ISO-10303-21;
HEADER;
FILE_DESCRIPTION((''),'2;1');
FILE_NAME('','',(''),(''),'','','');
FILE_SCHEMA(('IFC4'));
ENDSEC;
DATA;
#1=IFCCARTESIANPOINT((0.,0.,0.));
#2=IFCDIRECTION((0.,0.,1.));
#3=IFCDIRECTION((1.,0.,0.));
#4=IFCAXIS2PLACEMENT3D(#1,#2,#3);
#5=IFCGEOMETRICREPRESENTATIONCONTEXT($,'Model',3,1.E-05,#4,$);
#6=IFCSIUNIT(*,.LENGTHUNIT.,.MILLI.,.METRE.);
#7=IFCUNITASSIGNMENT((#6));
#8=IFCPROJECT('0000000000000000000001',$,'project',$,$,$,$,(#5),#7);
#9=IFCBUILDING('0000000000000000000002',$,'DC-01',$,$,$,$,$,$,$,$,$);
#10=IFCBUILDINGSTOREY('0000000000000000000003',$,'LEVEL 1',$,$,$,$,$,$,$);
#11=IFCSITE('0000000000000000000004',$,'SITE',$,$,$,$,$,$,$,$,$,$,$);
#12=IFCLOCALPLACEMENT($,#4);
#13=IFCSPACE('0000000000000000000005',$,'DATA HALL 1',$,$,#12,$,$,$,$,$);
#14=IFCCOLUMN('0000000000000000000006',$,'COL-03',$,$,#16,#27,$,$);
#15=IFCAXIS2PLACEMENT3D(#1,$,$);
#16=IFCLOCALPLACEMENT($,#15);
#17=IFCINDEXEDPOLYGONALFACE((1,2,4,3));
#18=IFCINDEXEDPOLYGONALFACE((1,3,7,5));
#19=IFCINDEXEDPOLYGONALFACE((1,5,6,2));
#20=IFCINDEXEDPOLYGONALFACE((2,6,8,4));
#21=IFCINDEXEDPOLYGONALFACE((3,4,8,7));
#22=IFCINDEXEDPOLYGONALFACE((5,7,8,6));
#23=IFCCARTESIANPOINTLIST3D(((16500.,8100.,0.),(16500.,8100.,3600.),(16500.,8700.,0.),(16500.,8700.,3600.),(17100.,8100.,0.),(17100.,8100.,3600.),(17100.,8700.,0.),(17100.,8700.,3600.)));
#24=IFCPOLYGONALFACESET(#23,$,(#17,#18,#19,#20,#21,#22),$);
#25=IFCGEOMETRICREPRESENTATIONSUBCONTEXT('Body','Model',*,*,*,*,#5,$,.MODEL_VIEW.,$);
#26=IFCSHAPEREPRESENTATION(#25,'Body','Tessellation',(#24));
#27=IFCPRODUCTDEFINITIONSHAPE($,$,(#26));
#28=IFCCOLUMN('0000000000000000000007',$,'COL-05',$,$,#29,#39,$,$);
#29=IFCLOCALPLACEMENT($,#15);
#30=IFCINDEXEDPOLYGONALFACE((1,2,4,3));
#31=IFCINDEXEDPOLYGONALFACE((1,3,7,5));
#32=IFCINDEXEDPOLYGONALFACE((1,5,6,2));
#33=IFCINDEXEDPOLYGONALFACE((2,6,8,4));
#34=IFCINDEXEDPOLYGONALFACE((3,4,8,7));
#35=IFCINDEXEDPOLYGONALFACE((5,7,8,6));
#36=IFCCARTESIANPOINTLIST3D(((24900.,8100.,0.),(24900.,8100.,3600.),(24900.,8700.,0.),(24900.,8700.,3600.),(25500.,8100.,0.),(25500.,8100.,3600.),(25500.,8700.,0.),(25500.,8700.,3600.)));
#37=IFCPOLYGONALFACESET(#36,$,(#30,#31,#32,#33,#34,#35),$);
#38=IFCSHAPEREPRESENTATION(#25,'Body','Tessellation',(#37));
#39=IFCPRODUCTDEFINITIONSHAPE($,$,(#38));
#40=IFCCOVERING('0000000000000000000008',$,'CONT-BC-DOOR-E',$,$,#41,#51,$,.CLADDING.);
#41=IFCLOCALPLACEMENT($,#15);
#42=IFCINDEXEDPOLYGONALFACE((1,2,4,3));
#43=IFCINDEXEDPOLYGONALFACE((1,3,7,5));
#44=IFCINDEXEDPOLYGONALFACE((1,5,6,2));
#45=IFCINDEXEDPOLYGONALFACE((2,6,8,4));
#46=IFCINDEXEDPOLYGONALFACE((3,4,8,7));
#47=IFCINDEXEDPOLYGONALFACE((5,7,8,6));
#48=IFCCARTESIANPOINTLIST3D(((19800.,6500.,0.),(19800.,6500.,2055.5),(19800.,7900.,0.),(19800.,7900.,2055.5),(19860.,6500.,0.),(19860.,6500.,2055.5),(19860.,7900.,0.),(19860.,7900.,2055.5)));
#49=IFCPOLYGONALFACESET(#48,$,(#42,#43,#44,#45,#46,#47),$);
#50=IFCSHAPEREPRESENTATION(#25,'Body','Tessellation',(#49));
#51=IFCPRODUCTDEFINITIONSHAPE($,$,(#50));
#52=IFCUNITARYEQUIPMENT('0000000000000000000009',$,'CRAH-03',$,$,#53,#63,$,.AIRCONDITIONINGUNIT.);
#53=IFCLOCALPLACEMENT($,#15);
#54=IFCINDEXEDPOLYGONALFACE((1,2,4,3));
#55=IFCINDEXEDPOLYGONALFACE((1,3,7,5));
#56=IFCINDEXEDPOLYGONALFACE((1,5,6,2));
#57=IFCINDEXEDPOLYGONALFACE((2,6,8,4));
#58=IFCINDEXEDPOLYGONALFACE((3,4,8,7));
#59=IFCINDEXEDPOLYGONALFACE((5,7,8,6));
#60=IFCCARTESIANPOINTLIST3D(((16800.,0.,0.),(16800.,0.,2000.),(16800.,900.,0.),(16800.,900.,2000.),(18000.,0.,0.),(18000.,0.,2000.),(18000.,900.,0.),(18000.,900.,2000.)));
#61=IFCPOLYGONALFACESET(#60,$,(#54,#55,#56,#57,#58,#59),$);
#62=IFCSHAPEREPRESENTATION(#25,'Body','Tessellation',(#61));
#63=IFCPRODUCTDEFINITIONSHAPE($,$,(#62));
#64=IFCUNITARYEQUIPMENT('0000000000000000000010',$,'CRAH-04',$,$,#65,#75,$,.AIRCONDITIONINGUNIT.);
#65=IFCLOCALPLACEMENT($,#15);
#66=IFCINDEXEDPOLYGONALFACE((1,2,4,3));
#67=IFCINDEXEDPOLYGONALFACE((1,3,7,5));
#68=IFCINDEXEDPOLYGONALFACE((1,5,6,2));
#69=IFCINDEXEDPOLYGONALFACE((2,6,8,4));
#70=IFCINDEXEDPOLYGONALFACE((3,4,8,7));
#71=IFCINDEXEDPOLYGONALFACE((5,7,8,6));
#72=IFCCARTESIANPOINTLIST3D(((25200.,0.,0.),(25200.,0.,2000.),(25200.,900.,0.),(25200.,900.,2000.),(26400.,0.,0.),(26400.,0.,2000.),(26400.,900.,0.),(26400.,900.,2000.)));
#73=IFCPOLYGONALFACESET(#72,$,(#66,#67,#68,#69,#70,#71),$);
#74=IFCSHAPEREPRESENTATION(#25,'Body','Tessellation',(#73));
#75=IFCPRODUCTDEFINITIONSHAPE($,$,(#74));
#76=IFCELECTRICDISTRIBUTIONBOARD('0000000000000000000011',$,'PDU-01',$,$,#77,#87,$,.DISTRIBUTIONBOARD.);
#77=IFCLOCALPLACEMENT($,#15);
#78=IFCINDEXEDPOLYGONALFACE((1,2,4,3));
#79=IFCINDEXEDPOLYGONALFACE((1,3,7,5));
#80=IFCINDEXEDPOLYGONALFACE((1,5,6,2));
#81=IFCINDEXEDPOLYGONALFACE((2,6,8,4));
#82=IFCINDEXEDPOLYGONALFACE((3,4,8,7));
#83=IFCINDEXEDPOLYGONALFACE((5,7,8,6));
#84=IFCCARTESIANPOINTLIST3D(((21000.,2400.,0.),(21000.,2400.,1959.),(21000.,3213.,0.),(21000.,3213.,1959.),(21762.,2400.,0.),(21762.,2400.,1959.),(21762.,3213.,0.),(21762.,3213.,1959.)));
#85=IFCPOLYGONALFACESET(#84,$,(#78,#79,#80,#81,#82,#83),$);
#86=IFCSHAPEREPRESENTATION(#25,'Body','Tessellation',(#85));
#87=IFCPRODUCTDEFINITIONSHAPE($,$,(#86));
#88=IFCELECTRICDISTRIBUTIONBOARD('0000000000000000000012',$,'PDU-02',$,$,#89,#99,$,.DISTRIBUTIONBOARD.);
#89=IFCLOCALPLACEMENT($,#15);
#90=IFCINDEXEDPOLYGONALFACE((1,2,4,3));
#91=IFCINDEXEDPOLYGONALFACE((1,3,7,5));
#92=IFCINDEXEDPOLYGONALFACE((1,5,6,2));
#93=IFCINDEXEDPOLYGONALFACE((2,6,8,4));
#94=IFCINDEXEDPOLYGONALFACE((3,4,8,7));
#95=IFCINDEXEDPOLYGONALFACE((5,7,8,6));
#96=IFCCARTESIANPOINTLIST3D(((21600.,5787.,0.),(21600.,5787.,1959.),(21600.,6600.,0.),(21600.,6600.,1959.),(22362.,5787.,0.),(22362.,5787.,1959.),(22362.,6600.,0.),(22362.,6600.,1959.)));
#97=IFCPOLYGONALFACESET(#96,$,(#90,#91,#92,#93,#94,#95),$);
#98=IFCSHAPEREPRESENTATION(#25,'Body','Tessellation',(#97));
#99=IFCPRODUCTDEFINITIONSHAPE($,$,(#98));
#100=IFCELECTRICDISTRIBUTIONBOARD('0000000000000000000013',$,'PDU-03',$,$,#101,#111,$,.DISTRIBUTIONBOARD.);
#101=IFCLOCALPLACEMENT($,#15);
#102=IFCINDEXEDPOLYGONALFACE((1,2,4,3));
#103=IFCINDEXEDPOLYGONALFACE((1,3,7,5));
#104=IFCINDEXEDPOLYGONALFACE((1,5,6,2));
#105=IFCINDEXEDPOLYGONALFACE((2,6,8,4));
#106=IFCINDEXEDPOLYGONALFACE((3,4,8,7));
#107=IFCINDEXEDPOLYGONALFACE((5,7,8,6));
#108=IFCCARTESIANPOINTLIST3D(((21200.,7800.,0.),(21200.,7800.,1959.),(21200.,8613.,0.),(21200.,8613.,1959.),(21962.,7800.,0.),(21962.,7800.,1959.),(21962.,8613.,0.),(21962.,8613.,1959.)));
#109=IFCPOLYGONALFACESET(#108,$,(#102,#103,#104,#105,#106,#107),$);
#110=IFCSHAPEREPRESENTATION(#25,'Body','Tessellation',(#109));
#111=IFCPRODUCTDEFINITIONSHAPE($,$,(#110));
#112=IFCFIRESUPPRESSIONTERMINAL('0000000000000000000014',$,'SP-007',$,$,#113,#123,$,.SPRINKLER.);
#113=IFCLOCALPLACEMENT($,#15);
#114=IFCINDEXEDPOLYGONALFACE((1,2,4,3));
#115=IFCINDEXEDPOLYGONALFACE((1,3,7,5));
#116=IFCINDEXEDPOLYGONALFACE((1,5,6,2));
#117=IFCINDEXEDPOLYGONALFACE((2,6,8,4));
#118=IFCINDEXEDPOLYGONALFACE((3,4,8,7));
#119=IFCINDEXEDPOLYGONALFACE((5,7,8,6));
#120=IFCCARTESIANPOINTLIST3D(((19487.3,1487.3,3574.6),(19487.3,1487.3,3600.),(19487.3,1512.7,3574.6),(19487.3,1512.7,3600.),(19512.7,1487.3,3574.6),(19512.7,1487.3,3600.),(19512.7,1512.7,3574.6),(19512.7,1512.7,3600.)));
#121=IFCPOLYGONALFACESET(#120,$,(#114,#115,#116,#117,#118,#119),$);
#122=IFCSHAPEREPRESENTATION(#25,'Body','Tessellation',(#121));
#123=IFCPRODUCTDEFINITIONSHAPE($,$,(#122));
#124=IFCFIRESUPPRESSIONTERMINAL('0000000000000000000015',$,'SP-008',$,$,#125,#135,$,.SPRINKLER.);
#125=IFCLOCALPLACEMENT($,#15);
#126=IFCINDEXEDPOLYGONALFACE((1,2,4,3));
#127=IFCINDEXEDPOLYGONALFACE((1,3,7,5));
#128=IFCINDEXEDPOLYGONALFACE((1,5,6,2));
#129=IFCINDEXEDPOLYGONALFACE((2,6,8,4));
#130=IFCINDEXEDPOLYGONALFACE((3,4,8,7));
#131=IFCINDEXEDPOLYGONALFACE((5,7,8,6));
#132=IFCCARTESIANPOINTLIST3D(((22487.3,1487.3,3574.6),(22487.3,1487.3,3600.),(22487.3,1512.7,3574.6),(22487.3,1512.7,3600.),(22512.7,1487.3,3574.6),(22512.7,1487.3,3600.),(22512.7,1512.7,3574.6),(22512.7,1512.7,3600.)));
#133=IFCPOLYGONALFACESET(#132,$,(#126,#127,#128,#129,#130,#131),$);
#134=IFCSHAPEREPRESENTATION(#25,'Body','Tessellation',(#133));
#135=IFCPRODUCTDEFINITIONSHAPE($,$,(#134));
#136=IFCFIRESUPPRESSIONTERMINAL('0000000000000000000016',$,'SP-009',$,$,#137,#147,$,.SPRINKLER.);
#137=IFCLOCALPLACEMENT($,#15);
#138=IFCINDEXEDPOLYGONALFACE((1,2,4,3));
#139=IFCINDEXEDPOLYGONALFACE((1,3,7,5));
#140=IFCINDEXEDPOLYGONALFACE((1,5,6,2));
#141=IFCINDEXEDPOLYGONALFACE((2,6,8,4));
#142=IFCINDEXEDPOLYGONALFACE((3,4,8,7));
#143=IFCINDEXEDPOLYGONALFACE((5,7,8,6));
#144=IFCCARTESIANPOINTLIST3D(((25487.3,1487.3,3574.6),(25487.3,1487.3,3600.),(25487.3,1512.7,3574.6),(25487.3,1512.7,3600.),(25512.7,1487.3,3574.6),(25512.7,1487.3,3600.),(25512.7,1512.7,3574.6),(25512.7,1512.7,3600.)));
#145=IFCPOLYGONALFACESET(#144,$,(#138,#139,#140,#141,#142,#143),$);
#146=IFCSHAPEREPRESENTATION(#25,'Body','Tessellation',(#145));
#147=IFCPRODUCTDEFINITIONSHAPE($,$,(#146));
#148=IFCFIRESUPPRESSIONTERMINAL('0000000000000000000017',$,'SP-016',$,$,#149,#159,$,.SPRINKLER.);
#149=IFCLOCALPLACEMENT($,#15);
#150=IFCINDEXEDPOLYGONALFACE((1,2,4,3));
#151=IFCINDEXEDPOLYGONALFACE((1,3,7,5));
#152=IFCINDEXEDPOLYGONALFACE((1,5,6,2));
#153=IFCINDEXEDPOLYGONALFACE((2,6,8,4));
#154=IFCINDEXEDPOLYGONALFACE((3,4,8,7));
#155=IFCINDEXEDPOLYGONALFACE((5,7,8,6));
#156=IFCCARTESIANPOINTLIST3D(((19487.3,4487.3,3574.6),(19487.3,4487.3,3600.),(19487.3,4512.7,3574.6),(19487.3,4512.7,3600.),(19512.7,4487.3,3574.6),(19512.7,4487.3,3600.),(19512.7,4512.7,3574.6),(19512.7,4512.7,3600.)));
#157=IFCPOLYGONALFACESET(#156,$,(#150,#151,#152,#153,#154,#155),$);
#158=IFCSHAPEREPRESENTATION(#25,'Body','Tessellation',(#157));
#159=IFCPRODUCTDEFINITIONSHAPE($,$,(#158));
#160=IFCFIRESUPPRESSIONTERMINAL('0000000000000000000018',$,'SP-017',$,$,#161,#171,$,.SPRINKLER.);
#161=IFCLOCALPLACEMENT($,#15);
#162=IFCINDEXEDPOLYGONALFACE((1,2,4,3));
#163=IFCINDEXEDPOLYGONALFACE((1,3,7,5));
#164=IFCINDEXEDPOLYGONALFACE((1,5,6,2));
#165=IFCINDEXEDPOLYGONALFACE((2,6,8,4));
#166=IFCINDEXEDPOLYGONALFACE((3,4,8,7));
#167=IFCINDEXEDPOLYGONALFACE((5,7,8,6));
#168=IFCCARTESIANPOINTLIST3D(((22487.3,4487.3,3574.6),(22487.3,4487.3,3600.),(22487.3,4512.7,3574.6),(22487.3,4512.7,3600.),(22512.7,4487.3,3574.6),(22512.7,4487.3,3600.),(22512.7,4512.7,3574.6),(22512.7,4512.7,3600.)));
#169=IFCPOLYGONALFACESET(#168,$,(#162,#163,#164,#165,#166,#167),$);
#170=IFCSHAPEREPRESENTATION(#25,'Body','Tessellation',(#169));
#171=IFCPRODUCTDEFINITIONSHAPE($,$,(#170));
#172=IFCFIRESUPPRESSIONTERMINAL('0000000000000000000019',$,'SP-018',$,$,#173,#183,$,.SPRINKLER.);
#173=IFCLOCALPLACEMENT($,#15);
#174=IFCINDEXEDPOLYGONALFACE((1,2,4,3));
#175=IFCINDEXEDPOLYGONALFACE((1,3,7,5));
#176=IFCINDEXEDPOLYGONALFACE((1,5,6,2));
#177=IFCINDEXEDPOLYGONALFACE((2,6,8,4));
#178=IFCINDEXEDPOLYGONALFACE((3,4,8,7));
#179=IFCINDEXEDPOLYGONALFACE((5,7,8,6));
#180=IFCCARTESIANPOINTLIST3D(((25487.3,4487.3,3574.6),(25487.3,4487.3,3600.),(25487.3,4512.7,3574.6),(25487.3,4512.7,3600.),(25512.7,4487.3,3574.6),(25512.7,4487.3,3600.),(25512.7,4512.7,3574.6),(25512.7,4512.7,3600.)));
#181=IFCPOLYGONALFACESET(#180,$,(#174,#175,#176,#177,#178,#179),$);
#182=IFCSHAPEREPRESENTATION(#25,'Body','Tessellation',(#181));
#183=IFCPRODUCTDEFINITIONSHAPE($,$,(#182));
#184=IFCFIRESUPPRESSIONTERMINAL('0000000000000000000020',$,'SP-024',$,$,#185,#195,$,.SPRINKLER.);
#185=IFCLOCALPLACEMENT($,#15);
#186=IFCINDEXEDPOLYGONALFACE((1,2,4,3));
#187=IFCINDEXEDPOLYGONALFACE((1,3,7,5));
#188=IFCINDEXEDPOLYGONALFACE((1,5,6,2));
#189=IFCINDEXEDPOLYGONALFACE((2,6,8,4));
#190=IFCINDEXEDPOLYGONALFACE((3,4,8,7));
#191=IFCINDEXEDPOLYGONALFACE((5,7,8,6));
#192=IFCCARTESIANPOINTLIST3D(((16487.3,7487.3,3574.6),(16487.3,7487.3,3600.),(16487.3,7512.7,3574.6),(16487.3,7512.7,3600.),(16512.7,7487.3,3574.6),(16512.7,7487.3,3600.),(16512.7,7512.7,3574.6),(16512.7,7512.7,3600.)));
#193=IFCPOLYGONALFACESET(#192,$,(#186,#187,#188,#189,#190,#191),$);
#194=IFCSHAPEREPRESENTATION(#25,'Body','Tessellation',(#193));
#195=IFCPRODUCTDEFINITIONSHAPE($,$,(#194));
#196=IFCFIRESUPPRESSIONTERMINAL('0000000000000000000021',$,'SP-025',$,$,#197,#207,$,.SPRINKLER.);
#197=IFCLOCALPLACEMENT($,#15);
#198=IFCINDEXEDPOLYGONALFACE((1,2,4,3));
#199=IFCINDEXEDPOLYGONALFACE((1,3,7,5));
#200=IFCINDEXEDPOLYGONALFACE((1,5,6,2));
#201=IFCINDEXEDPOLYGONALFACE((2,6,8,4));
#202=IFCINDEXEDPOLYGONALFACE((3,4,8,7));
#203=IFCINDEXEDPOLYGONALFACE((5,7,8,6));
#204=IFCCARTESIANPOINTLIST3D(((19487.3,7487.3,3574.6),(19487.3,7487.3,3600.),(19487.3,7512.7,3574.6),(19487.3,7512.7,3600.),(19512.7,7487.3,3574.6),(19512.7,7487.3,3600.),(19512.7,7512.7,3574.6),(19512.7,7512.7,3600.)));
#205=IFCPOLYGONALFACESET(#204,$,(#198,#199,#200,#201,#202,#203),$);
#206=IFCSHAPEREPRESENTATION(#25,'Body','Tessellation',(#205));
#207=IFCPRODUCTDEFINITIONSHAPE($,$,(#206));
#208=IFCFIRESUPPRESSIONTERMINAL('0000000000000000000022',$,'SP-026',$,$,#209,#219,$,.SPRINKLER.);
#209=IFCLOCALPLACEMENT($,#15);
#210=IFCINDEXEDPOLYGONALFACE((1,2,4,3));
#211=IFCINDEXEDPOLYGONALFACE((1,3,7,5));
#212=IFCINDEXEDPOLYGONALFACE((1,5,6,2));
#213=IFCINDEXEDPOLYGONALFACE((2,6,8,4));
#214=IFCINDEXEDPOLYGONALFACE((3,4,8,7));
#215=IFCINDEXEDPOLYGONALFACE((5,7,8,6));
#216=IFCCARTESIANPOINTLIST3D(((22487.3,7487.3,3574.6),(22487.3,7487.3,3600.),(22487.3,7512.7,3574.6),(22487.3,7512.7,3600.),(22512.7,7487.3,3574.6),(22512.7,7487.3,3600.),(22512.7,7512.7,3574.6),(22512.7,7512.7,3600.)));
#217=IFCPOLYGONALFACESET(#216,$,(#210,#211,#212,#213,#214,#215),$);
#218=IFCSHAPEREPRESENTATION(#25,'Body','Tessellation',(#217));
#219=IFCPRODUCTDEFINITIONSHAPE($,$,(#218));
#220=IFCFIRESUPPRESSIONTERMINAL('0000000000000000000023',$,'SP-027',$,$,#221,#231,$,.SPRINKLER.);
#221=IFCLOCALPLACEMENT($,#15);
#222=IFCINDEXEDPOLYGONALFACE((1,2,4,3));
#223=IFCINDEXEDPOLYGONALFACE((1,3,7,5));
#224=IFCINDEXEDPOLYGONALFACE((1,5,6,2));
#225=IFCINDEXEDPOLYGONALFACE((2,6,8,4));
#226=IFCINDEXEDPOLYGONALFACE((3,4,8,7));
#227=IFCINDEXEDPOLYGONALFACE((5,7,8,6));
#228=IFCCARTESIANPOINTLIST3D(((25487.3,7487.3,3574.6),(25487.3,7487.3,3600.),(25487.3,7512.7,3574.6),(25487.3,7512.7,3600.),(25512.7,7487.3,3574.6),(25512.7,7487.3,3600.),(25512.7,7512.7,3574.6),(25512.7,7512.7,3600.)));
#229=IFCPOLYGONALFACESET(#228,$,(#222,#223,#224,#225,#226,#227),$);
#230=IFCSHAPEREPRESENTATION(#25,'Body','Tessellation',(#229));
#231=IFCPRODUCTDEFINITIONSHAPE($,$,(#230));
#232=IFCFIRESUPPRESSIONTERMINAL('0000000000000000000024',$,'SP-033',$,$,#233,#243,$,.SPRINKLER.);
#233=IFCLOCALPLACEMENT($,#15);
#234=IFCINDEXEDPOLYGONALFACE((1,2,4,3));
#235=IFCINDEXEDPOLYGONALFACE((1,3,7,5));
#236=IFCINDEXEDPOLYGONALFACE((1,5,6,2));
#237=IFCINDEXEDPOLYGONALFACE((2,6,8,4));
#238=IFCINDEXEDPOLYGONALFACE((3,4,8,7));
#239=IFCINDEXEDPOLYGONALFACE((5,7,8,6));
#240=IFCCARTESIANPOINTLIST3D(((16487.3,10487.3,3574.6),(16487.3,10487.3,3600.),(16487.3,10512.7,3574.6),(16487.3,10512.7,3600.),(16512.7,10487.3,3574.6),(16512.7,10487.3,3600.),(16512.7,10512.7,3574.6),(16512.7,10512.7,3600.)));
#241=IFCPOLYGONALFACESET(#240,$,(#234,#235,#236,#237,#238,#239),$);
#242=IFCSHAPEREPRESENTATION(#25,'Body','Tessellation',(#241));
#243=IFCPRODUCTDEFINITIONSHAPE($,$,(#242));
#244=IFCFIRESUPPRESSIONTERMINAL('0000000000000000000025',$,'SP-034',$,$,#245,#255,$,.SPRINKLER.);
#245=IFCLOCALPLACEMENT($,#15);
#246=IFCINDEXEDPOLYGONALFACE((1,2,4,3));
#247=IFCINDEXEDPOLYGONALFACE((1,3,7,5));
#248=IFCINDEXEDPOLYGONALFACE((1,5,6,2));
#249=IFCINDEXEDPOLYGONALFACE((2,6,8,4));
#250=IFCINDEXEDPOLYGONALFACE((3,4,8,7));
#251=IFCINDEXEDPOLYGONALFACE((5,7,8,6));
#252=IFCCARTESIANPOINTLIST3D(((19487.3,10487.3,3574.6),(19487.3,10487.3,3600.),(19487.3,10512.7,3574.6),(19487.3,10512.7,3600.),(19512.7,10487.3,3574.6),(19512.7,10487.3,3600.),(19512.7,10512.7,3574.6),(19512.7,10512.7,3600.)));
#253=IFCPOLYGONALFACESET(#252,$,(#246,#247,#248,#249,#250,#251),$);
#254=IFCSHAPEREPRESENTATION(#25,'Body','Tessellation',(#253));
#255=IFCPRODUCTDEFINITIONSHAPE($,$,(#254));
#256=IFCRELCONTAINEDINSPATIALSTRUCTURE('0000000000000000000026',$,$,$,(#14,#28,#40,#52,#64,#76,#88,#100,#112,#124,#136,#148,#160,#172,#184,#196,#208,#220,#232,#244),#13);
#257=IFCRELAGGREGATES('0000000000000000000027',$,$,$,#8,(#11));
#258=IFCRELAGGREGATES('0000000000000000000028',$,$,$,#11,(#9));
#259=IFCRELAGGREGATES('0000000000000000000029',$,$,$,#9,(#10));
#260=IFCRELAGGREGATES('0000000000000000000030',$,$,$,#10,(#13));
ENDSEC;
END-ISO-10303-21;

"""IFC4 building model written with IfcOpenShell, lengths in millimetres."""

from ifc_helpers import new_model, si_unit, frame, origin, origin_with_axes, place, context, subcontext, project, spatial, polyline, outline, extrude, element, save


model = new_model("IFC4")

# Units and contexts
model_context = context("Model", 3, precision=1e-05, world=origin_with_axes())
body_context = subcontext(model_context, "Body", "Model", "MODEL_VIEW")
ifc_project = project(units=[si_unit("LENGTHUNIT", "METRE", prefix="MILLI")], contexts=[model_context])

# Site, building, storey, space
site = spatial("IfcSite", under=ifc_project, Name="SITE")
building = spatial("IfcBuilding", under=site, Name="DC-01")
storey = spatial("IfcBuildingStorey", under=building, Name="LEVEL 1")
space_placement = place(None, origin_with_axes())
space = spatial("IfcSpace", under=storey, at=space_placement, Name="DATA HALL 1")

# Columns
for number, where, z_axis, x_axis, name in (
    (1, (16500.0, 8100.0, 0.0), (0.0, 0.0, 1.0), (1.0, 0.0, 0.0), "COL-03"),
    (2, (24900.0, 8100.0, 0.0), (0.0, 0.0, 1.0), (1.0, 0.0, 0.0), "COL-05"),
):
    element("IfcColumn", number, at=place(space_placement, frame(where, z_axis=z_axis, x_axis=x_axis)), inside=space, Name=name, context=body_context, shape_type="SweptSolid", body=[
        extrude(outline(polyline([(0.0, 0.0), (600.0, 0.0), (600.0, 600.0), (0.0, 600.0), (0.0, 0.0)])), origin(), (0.0, 0.0, 1.0), 3600.0),
    ])

# Covering
covering_placement = place(space_placement, frame((19800.0, 6500.0, 0.0), z_axis=(0.0, 0.0, 1.0), x_axis=(1.0, 0.0, 0.0)))
element("IfcCovering", 3, at=covering_placement, inside=space, Name="CONT-BC-DOOR-E", PredefinedType="CLADDING", context=body_context, shape_type="SweptSolid", body=[
    extrude(outline(polyline([(0.0, 0.0), (60.0, 0.0), (60.0, 1400.0), (0.0, 1400.0), (0.0, 0.0)])), origin(), (0.0, 0.0, 1.0), 2055.5),
])

# Unitary equipment
for number, where, z_axis, x_axis, name in (
    (4, (16800.0, 0.0, 0.0), (0.0, 0.0, 1.0), (1.0, 0.0, 0.0), "CRAH-03"),
    (5, (25200.0, 0.0, 0.0), (0.0, 0.0, 1.0), (1.0, 0.0, 0.0), "CRAH-04"),
):
    element("IfcUnitaryEquipment", number, at=place(space_placement, frame(where, z_axis=z_axis, x_axis=x_axis)), inside=space, Name=name, PredefinedType="AIRCONDITIONINGUNIT", context=body_context, shape_type="SweptSolid", body=[
        extrude(outline(polyline([(0.0, 0.0), (1200.0, 0.0), (1200.0, 900.0), (0.0, 900.0), (0.0, 0.0)])), origin(), (0.0, 0.0, 1.0), 2000.0),
    ])

# Electric distribution boards
for number, where, z_axis, x_axis, name in (
    (6, (21762.0, 3213.0, 0.0), (0.0, 0.0, 1.0), (-1.0, 0.0, 0.0), "PDU-01"),
    (7, (21600.0, 5787.0, 0.0), (0.0, 0.0, 1.0), (1.0, 0.0, 0.0), "PDU-02"),
    (8, (21962.0, 8613.0, 0.0), (0.0, 0.0, 1.0), (-1.0, 0.0, 0.0), "PDU-03"),
):
    element("IfcElectricDistributionBoard", number, at=place(space_placement, frame(where, z_axis=z_axis, x_axis=x_axis)), inside=space, Name=name, PredefinedType="DISTRIBUTIONBOARD", context=body_context, shape_type="SweptSolid", body=[
        extrude(outline(polyline([(0.0, 0.0), (762.0, 0.0), (762.0, 813.0), (0.0, 813.0), (0.0, 0.0)])), origin(), (0.0, 0.0, 1.0), 1959.0),
    ])

# Fire suppression terminals
for number, where, z_axis, x_axis, name in (
    (9, (19487.3, 1487.3, 3574.6), (0.0, 0.0, 1.0), (1.0, 0.0, 0.0), "SP-007"),
    (10, (22487.3, 1487.3, 3574.6), (0.0, 0.0, 1.0), (1.0, 0.0, 0.0), "SP-008"),
    (11, (25487.3, 1487.3, 3574.6), (0.0, 0.0, 1.0), (1.0, 0.0, 0.0), "SP-009"),
    (12, (19487.3, 4487.3, 3574.6), (0.0, 0.0, 1.0), (1.0, 0.0, 0.0), "SP-016"),
    (13, (22487.3, 4487.3, 3574.6), (0.0, 0.0, 1.0), (1.0, 0.0, 0.0), "SP-017"),
    (14, (25487.3, 4487.3, 3574.6), (0.0, 0.0, 1.0), (1.0, 0.0, 0.0), "SP-018"),
    (15, (16487.3, 7487.3, 3574.6), (0.0, 0.0, 1.0), (1.0, 0.0, 0.0), "SP-024"),
    (16, (19487.3, 7487.3, 3574.6), (0.0, 0.0, 1.0), (1.0, 0.0, 0.0), "SP-025"),
    (17, (22487.3, 7487.3, 3574.6), (0.0, 0.0, 1.0), (1.0, 0.0, 0.0), "SP-026"),
    (18, (25487.3, 7487.3, 3574.6), (0.0, 0.0, 1.0), (1.0, 0.0, 0.0), "SP-027"),
    (19, (16487.3, 10487.3, 3574.6), (0.0, 0.0, 1.0), (1.0, 0.0, 0.0), "SP-033"),
    (20, (19487.3, 10487.3, 3574.6), (0.0, 0.0, 1.0), (1.0, 0.0, 0.0), "SP-034"),
):
    element("IfcFireSuppressionTerminal", number, at=place(space_placement, frame(where, z_axis=z_axis, x_axis=x_axis)), inside=space, Name=name, PredefinedType="SPRINKLER", context=body_context, shape_type="SweptSolid", body=[
        extrude(outline(polyline([(0.0, 0.0), (25.4, 0.0), (25.4, 25.4), (0.0, 25.4), (0.0, 0.0)])), origin(), (0.0, 0.0, 1.0), 25.4),
    ])

save(model, "model.ifc")
